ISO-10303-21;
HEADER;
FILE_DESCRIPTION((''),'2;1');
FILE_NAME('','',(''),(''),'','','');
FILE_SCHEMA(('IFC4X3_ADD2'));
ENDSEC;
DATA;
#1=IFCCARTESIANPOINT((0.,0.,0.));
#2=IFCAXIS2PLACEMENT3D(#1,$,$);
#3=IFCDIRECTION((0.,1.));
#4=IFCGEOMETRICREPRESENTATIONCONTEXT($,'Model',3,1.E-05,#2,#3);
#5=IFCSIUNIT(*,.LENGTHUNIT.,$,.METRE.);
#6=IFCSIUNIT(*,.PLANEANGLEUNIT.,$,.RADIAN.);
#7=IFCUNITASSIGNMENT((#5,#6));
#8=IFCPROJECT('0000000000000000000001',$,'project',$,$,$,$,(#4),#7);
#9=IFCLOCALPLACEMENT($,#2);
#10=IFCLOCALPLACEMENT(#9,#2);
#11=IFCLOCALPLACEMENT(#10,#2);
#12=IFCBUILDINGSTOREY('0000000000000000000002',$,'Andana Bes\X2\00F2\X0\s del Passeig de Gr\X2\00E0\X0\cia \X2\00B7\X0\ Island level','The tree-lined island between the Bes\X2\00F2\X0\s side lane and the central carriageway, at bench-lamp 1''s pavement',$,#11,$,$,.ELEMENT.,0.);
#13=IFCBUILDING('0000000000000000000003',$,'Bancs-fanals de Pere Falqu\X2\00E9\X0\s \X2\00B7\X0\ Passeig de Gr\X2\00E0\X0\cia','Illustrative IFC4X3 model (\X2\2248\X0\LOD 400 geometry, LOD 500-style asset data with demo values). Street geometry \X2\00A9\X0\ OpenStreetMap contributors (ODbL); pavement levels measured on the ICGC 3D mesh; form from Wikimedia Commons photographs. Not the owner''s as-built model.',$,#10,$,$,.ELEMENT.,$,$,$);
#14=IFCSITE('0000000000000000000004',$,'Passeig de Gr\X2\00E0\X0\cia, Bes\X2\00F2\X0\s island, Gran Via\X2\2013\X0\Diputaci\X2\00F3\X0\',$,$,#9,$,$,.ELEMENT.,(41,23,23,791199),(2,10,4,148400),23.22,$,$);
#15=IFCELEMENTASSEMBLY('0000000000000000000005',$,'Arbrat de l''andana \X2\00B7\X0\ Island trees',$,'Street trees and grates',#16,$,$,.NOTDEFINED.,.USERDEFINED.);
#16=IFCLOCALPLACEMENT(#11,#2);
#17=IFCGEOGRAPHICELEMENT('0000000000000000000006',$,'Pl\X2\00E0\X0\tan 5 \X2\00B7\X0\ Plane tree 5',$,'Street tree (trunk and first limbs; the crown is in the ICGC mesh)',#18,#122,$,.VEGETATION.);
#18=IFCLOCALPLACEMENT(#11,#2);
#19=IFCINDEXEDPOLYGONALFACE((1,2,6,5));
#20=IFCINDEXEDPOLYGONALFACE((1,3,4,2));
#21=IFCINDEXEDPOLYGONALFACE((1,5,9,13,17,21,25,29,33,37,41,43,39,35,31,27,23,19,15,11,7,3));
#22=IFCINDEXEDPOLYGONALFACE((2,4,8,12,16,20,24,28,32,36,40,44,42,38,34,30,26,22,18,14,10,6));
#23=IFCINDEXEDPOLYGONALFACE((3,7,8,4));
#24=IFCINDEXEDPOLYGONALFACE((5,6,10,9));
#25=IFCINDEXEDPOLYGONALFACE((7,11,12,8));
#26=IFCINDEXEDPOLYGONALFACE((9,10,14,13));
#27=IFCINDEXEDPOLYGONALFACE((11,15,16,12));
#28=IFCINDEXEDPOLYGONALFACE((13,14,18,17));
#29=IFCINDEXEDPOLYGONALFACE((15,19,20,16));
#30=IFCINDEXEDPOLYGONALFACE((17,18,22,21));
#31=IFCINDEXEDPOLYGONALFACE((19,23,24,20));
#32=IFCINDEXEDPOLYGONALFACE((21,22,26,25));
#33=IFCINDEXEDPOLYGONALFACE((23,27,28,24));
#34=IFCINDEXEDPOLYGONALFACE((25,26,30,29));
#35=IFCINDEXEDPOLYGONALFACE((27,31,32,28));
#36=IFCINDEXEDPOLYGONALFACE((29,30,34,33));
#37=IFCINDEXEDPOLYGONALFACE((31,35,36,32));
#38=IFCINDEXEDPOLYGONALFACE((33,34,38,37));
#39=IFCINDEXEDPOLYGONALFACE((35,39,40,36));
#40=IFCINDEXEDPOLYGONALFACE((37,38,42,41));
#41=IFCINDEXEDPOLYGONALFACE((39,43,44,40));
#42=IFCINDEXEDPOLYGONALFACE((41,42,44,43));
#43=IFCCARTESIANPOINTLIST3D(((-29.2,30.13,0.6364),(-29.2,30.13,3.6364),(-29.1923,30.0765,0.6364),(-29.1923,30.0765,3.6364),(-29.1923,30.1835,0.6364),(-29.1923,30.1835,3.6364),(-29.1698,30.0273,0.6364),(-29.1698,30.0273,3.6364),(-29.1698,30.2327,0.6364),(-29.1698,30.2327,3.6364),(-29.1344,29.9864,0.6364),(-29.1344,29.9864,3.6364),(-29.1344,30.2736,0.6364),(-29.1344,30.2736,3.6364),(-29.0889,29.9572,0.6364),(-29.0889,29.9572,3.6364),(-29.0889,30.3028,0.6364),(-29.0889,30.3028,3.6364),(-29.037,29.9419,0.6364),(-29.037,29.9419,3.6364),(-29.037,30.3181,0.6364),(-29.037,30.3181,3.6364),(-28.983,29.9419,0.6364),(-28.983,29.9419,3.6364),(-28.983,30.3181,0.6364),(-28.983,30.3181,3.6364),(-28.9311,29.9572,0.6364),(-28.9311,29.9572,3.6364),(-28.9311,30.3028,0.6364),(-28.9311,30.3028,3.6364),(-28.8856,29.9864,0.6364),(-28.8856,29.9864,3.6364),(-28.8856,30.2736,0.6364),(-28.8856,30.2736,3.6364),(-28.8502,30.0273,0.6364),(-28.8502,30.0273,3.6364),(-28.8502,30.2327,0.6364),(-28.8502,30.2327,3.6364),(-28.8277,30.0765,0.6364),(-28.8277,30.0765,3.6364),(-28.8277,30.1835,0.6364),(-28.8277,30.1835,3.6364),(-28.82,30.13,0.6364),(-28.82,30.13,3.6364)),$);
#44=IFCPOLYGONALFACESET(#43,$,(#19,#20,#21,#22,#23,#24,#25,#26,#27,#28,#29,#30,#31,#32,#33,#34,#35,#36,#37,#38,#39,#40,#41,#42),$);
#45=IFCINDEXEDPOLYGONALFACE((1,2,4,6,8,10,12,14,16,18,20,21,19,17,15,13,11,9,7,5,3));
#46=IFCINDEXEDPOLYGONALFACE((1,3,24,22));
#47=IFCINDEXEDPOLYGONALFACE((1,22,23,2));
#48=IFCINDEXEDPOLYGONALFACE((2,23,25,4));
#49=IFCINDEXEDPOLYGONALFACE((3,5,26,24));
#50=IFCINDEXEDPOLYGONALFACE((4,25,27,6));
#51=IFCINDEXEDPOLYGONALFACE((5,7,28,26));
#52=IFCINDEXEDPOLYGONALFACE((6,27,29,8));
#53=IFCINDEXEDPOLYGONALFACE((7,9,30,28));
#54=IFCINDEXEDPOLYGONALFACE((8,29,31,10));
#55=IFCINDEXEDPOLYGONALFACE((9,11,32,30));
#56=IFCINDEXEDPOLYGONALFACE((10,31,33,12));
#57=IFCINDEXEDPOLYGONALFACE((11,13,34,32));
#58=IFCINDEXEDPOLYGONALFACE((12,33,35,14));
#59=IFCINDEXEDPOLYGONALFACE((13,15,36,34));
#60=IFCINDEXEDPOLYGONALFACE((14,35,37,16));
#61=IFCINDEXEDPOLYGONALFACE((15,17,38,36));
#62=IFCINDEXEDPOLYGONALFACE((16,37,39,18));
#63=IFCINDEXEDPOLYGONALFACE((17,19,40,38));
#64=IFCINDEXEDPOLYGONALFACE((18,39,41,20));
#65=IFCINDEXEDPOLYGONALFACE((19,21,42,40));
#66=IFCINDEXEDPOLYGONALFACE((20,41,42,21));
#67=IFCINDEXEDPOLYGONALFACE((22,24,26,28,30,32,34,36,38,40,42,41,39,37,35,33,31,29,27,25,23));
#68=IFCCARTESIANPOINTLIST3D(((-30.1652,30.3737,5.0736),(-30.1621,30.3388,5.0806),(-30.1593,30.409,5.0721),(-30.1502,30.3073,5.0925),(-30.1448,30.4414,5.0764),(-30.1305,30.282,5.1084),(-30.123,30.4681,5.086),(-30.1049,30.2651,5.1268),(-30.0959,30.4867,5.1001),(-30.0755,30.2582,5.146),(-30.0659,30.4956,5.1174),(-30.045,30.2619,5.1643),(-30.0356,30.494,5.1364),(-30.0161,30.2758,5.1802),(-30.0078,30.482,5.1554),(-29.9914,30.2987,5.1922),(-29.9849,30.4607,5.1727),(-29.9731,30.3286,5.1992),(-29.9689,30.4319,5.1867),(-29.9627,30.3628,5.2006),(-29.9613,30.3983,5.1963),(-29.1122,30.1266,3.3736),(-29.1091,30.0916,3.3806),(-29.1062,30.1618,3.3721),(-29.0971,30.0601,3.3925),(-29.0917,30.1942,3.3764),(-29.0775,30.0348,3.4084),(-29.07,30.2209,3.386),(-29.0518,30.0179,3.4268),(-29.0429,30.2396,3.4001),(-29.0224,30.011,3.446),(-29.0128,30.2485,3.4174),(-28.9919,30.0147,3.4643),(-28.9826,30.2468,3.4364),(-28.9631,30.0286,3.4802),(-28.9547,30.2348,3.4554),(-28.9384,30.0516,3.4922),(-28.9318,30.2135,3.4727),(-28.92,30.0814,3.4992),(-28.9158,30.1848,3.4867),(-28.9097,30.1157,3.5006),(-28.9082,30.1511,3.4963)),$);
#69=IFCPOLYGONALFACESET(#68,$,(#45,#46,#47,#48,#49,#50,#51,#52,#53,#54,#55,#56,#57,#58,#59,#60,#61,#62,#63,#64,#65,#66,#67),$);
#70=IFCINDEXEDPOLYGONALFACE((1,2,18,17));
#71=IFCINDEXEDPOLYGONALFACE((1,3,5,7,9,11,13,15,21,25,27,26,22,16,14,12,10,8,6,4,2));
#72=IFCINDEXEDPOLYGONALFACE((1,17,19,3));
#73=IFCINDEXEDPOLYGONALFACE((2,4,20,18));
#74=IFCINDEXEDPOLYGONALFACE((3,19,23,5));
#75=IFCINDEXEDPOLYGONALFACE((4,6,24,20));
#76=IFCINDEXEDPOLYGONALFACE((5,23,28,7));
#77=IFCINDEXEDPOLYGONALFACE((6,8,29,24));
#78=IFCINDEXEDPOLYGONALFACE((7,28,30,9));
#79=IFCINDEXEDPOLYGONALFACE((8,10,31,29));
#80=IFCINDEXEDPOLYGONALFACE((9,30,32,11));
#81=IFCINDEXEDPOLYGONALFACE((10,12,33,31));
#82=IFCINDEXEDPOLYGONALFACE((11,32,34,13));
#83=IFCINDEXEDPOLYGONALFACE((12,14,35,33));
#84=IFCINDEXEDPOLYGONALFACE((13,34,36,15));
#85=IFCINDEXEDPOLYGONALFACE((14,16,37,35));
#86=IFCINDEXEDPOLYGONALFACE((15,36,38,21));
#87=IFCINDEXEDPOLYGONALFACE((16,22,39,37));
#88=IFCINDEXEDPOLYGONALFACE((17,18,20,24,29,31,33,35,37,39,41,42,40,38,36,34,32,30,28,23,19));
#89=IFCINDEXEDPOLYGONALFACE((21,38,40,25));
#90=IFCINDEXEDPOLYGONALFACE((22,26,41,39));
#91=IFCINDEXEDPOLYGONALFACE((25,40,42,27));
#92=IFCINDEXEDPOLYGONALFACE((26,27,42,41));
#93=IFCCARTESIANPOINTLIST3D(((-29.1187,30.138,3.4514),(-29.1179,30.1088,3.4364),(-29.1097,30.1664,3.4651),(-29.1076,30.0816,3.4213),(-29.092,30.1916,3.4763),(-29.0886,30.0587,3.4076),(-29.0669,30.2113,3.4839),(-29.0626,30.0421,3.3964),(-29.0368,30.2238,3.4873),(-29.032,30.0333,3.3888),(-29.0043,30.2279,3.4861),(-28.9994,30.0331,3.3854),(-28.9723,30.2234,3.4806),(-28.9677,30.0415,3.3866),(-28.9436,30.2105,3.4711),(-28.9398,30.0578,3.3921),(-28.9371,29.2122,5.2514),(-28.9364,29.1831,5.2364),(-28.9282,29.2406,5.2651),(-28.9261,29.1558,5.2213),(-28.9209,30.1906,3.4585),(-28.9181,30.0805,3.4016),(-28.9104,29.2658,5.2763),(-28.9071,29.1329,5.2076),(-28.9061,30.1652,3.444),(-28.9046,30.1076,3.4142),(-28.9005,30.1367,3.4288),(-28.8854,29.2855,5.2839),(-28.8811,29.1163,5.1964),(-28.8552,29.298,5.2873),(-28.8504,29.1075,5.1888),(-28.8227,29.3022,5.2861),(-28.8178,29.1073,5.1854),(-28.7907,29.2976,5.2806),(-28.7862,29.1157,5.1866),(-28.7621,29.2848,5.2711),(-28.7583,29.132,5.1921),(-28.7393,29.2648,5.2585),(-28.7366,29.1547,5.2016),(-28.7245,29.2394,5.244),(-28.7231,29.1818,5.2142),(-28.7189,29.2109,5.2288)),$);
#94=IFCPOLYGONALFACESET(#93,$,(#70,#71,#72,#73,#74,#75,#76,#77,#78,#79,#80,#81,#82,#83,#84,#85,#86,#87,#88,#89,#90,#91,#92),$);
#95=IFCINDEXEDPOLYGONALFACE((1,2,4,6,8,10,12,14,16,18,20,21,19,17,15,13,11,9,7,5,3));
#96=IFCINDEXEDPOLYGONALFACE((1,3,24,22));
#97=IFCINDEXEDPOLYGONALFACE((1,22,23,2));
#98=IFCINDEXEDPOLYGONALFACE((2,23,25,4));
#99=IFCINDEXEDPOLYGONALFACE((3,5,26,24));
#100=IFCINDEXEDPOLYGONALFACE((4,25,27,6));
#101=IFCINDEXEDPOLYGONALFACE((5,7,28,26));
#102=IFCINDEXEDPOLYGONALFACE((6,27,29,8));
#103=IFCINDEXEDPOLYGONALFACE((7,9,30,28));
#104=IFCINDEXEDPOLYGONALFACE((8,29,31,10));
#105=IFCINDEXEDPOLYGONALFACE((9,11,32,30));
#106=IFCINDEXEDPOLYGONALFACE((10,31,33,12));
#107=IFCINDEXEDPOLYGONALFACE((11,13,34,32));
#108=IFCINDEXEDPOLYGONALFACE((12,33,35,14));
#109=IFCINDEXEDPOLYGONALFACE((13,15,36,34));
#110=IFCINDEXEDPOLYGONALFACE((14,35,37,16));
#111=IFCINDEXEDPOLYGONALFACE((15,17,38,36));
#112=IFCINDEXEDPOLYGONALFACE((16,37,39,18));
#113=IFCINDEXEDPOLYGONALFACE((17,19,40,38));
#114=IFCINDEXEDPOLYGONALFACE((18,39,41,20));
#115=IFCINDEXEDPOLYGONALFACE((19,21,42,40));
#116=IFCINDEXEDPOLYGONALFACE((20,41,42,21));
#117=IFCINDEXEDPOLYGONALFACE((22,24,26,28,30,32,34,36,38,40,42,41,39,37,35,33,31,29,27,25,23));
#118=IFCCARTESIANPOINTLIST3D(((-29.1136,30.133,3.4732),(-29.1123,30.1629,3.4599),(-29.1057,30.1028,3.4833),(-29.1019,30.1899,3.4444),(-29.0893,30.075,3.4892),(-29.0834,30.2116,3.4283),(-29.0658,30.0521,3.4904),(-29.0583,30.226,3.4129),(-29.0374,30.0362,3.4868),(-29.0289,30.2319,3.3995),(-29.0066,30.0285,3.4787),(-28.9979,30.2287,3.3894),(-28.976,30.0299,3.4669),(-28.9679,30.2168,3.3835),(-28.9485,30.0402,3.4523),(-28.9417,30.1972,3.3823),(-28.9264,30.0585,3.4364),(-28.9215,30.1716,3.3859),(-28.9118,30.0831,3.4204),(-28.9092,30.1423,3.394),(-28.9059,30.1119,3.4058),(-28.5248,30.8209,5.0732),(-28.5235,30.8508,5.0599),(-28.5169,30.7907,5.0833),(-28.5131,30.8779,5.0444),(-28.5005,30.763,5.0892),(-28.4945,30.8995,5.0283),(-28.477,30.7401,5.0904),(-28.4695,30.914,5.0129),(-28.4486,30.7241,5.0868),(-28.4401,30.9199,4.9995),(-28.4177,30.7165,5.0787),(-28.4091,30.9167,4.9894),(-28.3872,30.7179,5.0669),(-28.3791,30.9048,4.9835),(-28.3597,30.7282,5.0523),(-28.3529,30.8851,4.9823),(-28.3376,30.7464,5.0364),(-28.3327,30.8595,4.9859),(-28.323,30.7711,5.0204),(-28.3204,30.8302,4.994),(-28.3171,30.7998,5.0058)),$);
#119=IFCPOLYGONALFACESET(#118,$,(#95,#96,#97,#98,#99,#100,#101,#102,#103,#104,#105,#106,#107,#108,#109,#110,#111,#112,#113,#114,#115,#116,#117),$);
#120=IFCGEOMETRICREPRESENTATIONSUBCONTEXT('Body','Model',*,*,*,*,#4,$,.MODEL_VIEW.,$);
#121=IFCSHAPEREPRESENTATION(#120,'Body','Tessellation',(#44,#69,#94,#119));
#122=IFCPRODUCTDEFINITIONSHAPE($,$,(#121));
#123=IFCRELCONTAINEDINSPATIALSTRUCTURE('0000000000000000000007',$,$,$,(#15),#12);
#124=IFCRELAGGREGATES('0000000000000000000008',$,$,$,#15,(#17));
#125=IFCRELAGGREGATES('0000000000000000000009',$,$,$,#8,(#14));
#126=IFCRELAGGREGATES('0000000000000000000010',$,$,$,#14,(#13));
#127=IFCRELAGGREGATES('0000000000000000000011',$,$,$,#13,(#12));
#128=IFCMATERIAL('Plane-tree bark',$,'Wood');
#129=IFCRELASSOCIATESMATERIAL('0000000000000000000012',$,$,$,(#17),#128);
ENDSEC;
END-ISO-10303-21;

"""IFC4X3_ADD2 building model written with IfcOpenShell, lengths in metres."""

from ifc_helpers import new_model, si_unit, direction, frame, origin, origin_2d_with_axis, place, context, subcontext, project, spatial, circle, extrude, material, element, aggregate, save


model = new_model("IFC4X3_ADD2")

# Units and contexts
model_context = context("Model", 3, precision=1e-05, world=origin(), true_north=direction((0.0, 1.0)))
body_context = subcontext(model_context, "Body", "Model", "MODEL_VIEW")
ifc_project = project(units=[si_unit("LENGTHUNIT", "METRE"), si_unit("PLANEANGLEUNIT", "RADIAN")], contexts=[model_context])

# Site, building, storey
site_placement = place(None, origin())
site = spatial("IfcSite", under=ifc_project, at=site_placement, Name="Passeig de Gràcia, Besòs island, Gran Via–Diputació", CompositionType="ELEMENT", RefLatitude=(41, 23, 23, 791199), RefLongitude=(2, 10, 4, 148400), RefElevation=23.22)
building_placement = place(site_placement, origin())
building = spatial("IfcBuilding", under=site, at=building_placement, Name="Bancs-fanals de Pere Falqués · Passeig de Gràcia", Description="Illustrative IFC4X3 model (≈LOD 400 geometry, LOD 500-style asset data with demo values). Street geometry © OpenStreetMap contributors (ODbL); pavement levels measured on the ICGC 3D mesh; form from Wikimedia Commons photographs. Not the owner's as-built model.", CompositionType="ELEMENT")
storey_placement = place(building_placement, origin())
storey = spatial("IfcBuildingStorey", under=building, at=storey_placement, Name="Andana Besòs del Passeig de Gràcia · Island level", Description="The tree-lined island between the Besòs side lane and the central carriageway, at bench-lamp 1's pavement", CompositionType="ELEMENT", Elevation=0.0)

# Element assembly
assembly_1_placement = place(building_placement, origin())
assembly_1 = element("IfcElementAssembly", 1, at=assembly_1_placement, inside=storey, Name="Arbrat de l'andana · Island trees", ObjectType="Street trees and grates", AssemblyPlace="NOTDEFINED", PredefinedType="USERDEFINED")

# Geographic element
ifc_material_1 = material(Name="Plane-tree bark", Category="Wood")
geographic_element_1_placement = place(building_placement, origin())
geographic_element_1 = element("IfcGeographicElement", 2, at=geographic_element_1_placement, material=ifc_material_1, Name="Plàtan 5 · Plane tree 5", ObjectType="Street tree (trunk and first limbs; the crown is in the ICGC mesh)", PredefinedType="VEGETATION", context=body_context, shape_type="SweptSolid", body=[
    extrude(circle(Radius=0.19, at=origin_2d_with_axis()), frame((-29.01, 30.13, 0.6364)), (0.0, 0.0, 1.0), 3.0),
    extrude(circle(Radius=0.12, at=origin_2d_with_axis()), frame((-29.01, 30.13, 3.4364), z_axis=(-0.522617, 0.122674, 0.843696), x_axis=(0.22852, 0.973539, 0.0)), (0.0, 0.0, 1.0), 2.0149),
    extrude(circle(Radius=0.11, at=origin_2d_with_axis()), frame((-29.01, 30.13, 3.4364), z_axis=(0.089329, -0.45554, 0.885722), x_axis=(-0.981311, -0.19243, 0.0)), (0.0, 0.0, 1.0), 2.0322),
    extrude(circle(Radius=0.11, at=origin_2d_with_axis()), frame((-29.01, 30.13, 3.4364), z_axis=(0.320275, 0.374202, 0.870285), x_axis=(0.759728, -0.650241, 0.0)), (0.0, 0.0, 1.0), 1.8385),
])
aggregate(assembly_1, [geographic_element_1])

save(model, "model.ifc")
